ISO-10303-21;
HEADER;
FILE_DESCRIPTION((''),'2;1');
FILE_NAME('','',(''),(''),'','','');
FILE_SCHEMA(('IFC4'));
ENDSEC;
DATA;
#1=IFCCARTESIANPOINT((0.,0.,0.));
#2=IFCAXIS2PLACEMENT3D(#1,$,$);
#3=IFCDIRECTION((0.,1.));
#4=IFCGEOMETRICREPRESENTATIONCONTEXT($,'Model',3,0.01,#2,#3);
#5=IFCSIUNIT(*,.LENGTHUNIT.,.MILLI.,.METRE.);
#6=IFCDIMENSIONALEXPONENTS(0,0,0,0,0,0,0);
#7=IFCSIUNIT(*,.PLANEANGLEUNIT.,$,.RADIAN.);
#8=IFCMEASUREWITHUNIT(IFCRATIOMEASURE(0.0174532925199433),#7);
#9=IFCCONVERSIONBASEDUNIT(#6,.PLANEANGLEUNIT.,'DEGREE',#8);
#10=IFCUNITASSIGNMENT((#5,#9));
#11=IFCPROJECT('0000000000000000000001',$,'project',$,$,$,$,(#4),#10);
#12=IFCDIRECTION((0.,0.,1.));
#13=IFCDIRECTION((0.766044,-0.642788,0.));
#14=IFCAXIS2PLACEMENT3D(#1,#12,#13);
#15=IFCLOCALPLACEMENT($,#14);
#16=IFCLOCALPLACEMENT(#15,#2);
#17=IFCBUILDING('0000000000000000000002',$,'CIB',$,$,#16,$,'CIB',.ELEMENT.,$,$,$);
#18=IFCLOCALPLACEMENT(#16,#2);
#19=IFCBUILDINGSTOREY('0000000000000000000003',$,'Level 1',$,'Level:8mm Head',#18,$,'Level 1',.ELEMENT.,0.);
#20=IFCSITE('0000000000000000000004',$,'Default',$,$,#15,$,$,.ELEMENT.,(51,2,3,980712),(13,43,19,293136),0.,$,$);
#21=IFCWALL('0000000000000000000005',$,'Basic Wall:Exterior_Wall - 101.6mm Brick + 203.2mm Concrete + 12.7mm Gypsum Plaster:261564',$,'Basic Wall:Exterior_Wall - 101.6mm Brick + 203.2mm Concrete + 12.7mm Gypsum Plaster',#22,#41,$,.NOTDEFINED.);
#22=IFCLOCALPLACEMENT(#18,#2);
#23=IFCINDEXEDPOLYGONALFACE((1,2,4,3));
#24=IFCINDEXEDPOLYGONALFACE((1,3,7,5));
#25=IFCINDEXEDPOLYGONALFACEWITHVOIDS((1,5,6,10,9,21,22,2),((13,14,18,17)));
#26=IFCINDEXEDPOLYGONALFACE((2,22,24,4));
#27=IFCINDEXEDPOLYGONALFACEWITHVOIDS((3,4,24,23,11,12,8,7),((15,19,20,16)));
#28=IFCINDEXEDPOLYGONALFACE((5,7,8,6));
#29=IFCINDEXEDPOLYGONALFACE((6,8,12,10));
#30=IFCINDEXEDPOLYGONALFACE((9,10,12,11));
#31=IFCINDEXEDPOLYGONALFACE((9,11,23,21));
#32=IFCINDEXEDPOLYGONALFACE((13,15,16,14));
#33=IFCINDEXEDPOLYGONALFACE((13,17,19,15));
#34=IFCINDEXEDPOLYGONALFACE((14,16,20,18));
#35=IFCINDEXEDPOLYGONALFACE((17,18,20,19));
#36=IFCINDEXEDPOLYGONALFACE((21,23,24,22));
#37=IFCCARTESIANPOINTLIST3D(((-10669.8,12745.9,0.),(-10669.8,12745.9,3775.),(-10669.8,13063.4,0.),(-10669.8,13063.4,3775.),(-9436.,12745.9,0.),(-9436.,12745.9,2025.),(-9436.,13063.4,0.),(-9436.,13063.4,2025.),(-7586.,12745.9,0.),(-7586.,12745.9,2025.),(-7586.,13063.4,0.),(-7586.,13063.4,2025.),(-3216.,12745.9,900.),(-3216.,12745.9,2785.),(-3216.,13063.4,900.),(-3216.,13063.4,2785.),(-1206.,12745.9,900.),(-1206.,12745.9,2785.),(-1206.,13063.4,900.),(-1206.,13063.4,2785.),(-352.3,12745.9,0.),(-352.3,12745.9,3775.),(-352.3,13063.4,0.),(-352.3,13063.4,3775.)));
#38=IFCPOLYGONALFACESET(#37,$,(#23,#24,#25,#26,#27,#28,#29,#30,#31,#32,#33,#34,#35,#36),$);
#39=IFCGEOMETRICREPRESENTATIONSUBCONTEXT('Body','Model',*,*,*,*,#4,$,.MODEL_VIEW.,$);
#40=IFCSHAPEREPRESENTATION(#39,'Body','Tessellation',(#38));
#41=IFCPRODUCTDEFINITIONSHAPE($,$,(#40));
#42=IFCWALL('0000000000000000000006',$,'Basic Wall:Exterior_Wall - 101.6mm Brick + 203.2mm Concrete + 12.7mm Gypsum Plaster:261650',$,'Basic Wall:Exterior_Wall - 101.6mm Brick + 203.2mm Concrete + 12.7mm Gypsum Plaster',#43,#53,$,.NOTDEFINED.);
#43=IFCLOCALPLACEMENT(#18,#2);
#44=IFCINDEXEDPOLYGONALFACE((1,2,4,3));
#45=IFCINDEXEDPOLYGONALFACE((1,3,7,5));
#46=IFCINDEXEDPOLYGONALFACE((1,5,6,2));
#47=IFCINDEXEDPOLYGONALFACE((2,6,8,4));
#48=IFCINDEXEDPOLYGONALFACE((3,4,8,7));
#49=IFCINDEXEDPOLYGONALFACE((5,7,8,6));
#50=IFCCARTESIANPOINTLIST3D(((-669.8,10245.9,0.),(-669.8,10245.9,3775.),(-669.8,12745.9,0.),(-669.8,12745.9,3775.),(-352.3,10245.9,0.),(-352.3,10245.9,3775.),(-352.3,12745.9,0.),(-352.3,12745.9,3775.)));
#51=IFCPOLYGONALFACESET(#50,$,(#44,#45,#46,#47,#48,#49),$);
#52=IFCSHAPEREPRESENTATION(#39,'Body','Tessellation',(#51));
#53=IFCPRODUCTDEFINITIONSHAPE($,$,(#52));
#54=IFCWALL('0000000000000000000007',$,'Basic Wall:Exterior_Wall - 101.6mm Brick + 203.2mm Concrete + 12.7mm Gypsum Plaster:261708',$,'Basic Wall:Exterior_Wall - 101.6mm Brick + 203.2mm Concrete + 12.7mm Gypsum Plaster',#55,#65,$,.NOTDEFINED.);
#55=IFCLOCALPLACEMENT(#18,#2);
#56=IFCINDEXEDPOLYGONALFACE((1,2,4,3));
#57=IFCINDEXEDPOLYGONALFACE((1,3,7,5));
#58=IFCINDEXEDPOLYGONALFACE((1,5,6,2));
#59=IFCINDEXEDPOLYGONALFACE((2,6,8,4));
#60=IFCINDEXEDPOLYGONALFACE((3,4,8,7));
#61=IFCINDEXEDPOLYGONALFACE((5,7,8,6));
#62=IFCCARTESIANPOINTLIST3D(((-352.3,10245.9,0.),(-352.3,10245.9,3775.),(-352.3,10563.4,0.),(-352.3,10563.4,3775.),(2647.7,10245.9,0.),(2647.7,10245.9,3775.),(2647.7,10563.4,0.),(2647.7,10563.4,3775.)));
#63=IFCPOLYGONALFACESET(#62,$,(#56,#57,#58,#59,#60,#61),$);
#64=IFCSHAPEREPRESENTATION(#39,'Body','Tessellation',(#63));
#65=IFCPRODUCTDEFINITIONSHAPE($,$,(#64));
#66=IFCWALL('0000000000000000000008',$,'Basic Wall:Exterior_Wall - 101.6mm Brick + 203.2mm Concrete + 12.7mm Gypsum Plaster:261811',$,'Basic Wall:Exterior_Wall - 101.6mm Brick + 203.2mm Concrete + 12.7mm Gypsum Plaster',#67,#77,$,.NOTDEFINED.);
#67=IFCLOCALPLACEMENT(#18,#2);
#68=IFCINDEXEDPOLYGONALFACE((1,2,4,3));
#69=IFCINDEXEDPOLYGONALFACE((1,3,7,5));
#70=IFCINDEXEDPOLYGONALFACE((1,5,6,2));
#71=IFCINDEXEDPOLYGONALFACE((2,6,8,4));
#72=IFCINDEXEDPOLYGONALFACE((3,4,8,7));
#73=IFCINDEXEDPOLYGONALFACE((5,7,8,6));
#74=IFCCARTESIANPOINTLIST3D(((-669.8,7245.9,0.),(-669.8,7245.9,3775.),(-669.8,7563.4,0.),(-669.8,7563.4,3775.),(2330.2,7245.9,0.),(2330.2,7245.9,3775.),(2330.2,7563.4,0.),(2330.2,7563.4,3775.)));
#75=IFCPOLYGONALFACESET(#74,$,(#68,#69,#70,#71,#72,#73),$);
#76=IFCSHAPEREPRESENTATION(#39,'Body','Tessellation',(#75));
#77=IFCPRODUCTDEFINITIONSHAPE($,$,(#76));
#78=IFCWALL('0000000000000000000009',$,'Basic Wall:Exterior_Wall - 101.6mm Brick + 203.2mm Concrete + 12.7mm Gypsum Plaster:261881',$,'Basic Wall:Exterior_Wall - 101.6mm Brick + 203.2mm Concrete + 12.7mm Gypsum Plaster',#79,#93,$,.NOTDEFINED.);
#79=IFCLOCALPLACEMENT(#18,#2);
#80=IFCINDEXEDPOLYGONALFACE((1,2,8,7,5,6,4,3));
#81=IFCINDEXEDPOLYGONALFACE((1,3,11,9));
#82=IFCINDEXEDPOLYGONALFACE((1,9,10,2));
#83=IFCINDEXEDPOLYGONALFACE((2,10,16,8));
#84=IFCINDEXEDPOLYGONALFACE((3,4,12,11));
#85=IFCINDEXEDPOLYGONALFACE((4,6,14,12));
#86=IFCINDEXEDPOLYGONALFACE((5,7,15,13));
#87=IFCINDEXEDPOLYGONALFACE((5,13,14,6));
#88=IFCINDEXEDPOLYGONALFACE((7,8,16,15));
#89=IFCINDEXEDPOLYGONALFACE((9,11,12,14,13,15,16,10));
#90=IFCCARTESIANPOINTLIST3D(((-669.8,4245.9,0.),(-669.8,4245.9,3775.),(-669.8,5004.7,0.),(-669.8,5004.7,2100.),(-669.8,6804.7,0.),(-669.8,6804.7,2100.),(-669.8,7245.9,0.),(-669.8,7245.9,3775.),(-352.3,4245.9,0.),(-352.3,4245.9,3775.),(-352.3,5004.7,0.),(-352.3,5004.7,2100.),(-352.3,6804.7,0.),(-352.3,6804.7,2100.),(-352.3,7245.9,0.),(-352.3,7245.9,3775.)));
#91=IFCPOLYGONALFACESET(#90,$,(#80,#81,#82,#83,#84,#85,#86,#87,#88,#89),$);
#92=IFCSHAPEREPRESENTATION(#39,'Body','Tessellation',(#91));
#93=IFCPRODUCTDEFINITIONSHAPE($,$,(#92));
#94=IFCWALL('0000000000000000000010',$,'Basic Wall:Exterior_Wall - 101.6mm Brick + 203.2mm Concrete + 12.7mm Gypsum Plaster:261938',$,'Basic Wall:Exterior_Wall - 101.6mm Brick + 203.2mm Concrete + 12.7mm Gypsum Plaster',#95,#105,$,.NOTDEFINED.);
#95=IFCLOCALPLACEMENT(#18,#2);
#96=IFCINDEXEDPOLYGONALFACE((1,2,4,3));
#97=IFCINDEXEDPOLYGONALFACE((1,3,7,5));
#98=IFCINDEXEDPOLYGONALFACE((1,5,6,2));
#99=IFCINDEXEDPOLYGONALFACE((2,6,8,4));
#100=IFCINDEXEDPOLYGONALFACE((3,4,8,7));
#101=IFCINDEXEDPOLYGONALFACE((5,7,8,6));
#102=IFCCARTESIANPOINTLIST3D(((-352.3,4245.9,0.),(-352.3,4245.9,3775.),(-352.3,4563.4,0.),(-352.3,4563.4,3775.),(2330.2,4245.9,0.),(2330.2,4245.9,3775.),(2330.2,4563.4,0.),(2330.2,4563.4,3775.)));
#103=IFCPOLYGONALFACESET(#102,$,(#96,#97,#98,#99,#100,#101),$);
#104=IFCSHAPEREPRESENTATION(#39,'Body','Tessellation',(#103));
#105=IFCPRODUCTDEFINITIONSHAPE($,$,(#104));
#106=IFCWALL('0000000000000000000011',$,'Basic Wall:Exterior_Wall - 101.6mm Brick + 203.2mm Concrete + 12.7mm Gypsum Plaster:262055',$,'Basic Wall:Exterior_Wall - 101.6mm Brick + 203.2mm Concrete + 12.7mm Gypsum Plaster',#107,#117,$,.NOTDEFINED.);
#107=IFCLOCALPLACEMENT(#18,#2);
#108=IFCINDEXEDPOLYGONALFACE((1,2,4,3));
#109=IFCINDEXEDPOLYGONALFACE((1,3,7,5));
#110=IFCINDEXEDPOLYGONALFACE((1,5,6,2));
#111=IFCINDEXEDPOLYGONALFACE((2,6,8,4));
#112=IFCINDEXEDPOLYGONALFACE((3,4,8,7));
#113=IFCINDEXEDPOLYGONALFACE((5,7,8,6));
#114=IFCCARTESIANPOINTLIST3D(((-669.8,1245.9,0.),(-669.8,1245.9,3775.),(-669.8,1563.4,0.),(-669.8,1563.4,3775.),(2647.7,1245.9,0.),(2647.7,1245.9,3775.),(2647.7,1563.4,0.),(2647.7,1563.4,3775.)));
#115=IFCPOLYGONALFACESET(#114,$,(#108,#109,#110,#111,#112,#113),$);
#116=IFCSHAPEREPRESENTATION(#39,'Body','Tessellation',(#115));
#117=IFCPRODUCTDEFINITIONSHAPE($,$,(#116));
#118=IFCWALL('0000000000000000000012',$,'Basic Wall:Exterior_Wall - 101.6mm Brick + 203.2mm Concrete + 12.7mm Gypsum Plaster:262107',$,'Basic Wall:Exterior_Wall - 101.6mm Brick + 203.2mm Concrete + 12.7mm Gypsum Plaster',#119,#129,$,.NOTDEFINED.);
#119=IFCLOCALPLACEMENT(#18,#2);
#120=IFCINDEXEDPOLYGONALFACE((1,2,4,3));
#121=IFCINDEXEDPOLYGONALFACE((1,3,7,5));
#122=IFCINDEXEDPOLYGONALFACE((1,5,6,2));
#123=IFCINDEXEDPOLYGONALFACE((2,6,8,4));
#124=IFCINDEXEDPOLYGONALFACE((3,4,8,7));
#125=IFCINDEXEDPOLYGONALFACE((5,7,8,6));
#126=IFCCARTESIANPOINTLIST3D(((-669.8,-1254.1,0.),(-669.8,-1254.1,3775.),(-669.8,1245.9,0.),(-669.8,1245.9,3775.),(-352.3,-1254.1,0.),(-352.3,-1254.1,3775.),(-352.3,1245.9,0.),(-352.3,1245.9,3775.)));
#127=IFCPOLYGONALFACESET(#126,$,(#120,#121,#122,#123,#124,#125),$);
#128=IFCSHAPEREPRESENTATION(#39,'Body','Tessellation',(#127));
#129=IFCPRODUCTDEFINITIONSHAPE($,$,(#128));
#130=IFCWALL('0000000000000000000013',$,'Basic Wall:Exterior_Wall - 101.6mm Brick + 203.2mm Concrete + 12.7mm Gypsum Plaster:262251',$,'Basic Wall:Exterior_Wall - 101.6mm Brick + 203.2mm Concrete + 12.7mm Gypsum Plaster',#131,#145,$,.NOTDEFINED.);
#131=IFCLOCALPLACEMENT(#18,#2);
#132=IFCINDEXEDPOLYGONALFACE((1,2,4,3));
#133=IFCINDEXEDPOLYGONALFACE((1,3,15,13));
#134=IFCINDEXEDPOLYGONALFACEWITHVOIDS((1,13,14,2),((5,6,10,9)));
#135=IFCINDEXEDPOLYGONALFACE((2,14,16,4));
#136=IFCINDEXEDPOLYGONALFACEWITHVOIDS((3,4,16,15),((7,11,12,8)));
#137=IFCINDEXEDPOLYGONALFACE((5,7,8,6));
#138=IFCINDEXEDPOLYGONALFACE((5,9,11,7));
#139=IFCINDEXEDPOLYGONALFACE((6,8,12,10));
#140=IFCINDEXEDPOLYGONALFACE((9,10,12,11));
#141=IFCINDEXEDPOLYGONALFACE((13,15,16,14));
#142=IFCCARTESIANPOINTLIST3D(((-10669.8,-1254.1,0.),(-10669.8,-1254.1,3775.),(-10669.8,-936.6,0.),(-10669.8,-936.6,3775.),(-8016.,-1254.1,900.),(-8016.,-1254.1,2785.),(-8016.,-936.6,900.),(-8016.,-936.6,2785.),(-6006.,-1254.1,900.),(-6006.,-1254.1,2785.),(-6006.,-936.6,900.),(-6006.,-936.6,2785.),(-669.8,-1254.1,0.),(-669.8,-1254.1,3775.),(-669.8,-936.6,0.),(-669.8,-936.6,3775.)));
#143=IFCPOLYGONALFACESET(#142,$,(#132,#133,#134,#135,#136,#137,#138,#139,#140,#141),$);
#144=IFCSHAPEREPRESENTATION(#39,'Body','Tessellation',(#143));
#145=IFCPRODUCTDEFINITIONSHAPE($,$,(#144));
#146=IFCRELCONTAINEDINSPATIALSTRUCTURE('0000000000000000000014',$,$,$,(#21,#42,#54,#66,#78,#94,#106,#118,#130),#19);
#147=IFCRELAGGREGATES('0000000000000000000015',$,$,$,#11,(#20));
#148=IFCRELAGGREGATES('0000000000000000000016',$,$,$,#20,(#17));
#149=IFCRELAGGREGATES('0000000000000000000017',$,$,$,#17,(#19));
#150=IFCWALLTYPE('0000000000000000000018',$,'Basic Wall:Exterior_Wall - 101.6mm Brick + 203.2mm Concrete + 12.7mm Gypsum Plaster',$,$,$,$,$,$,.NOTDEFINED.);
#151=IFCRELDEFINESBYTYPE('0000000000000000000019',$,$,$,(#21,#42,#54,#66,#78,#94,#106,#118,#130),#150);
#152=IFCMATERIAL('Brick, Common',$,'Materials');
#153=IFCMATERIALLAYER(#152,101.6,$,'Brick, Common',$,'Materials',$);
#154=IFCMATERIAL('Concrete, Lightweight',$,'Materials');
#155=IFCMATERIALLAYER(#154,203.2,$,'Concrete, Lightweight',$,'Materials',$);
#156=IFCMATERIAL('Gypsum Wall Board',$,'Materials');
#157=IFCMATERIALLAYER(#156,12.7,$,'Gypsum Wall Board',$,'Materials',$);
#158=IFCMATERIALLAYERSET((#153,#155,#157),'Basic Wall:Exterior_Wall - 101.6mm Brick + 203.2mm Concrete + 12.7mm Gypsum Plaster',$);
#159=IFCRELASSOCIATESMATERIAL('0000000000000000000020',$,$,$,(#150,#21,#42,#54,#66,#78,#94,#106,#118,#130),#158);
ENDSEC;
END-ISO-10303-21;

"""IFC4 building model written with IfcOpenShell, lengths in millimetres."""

from ifc_helpers import new_model, entity, si_unit, converted_unit, direction, frame, frame_2d, origin, place, context, subcontext, project, spatial, polyline, rectangle, extrude, clip, bounded_halfspace, material, layer, layer_set, layer_usage, type_object, element, save


model = new_model("IFC4")

# Units and contexts
model_context = context("Model", 3, precision=0.01, world=origin(), true_north=direction((0.0, 1.0)))
body_context = subcontext(model_context, "Body", "Model", "MODEL_VIEW")
ifc_project = project(units=[si_unit("LENGTHUNIT", "METRE", prefix="MILLI"), converted_unit("PLANEANGLEUNIT", "DEGREE", entity("IfcRatioMeasure", 0.0174532925199433), si_unit("PLANEANGLEUNIT", "RADIAN"), dimensions=[0, 0, 0, 0, 0, 0, 0])], contexts=[model_context])

# Site, building, storey
site_placement = place(None, frame((0.0, 0.0, 0.0), z_axis=(0.0, 0.0, 1.0), x_axis=(0.766044, -0.642788, 0.0)))
site = spatial("IfcSite", under=ifc_project, at=site_placement, Name="Default", CompositionType="ELEMENT", RefLatitude=(51, 2, 3, 980712), RefLongitude=(13, 43, 19, 293136), RefElevation=0.0)
building_placement = place(site_placement, origin())
building = spatial("IfcBuilding", under=site, at=building_placement, Name="CIB", LongName="CIB", CompositionType="ELEMENT")
storey_placement = place(building_placement, origin())
storey = spatial("IfcBuildingStorey", under=building, at=storey_placement, Name="Level 1", ObjectType="Level:8mm Head", LongName="Level 1", CompositionType="ELEMENT", Elevation=0.0)

# Wall, openings
ifc_material_1 = material(Name="Brick, Common", Category="Materials")
ifc_layer_1 = layer(ifc_material_1, 101.6, Name="Brick, Common", Category="Materials")
ifc_material_2 = material(Name="Concrete, Lightweight", Category="Materials")
ifc_layer_2 = layer(ifc_material_2, 203.2, Name="Concrete, Lightweight", Category="Materials")
ifc_material_3 = material(Name="Gypsum Wall Board", Category="Materials")
ifc_layer_3 = layer(ifc_material_3, 12.7, Name="Gypsum Wall Board", Category="Materials")
ifc_layer_set_1 = layer_set([ifc_layer_1, ifc_layer_2, ifc_layer_3], Name="Basic Wall:Exterior_Wall - 101.6mm Brick + 203.2mm Concrete + 12.7mm Gypsum Plaster")
ifc_layer_usage_1 = layer_usage(ifc_layer_set_1, "AXIS2", "NEGATIVE", 158.8)
wall_type_1 = type_object("IfcWallType", Name="Basic Wall:Exterior_Wall - 101.6mm Brick + 203.2mm Concrete + 12.7mm Gypsum Plaster", PredefinedType="NOTDEFINED", material=ifc_layer_set_1)
wall_1_placement = place(storey_placement, frame((-10669.8, 12904.7, 0.0)))
wall_1 = element("IfcWall", 1, at=wall_1_placement, inside=storey, type_object=wall_type_1, material=ifc_layer_usage_1, Name="Basic Wall:Exterior_Wall - 101.6mm Brick + 203.2mm Concrete + 12.7mm Gypsum Plaster:261564", ObjectType="Basic Wall:Exterior_Wall - 101.6mm Brick + 203.2mm Concrete + 12.7mm Gypsum Plaster", PredefinedType="NOTDEFINED", context=body_context, shape_type="Clipping", body=[
    clip(extrude(rectangle(XDim=10317.5, YDim=317.5, at=frame_2d((5158.7, 0.0), x_axis=(-1.0, 0.0))), origin(), (0.0, 0.0, 1.0), 3775.0), bounded_halfspace(frame((0.0, -158.7, 3775.0), z_axis=(0.0, 0.0, -1.0), x_axis=(1.0, 0.0, 0.0)), True, frame((0.0, -158.7, 3775.0)), polyline([(0.0, 0.0), (317.5, 0.0), (10000.0, 0.0), (10317.5, 0.0), (10317.5, 317.5), (0.0, 317.5), (0.0, 0.0)]))),
])
opening_1_placement = place(wall_1_placement, frame((3083.8, 158.7, 0.0)))
element("IfcOpeningElement", 2, at=opening_1_placement, cuts=wall_1, ObjectType="Opening", PredefinedType="OPENING", context=body_context, shape_type="SweptSolid", body=[
    extrude(rectangle(XDim=2025.0, YDim=1850.0, at=frame_2d((1012.5, 925.0), x_axis=(1.0, 0.0))), frame((0.0, 0.0, 0.0), z_axis=(0.0, -1.0, 0.0), x_axis=(0.0, 0.0, 1.0)), (0.0, 0.0, 1.0), 317.5),
])
opening_2_placement = place(wall_1_placement, frame((9463.7, 158.7, 900.0)))
element("IfcOpeningElement", 3, at=opening_2_placement, cuts=wall_1, ObjectType="Opening", PredefinedType="OPENING", context=body_context, shape_type="SweptSolid", body=[
    extrude(rectangle(XDim=1885.0, YDim=2010.0, at=frame_2d((942.5, 1005.0), x_axis=(1.0, 0.0))), frame((0.0, 0.0, 0.0), z_axis=(0.0, -1.0, 0.0), x_axis=(0.0, 0.0, 1.0)), (0.0, 0.0, 1.0), 317.5),
])

# Walls
ifc_layer_usage_2 = layer_usage(ifc_layer_set_1, "AXIS2", "NEGATIVE", 158.8)
wall_2_placement = place(storey_placement, frame((-511.0, 12745.9, 0.0), z_axis=(0.0, 0.0, 1.0), x_axis=(0.0, -1.0, 0.0)))
element("IfcWall", 4, at=wall_2_placement, inside=storey, type_object=wall_type_1, material=ifc_layer_usage_2, Name="Basic Wall:Exterior_Wall - 101.6mm Brick + 203.2mm Concrete + 12.7mm Gypsum Plaster:261650", ObjectType="Basic Wall:Exterior_Wall - 101.6mm Brick + 203.2mm Concrete + 12.7mm Gypsum Plaster", PredefinedType="NOTDEFINED", context=body_context, shape_type="Clipping", body=[
    clip(extrude(rectangle(XDim=2500.0, YDim=317.5, at=frame_2d((1250.0, 0.0), x_axis=(-1.0, 0.0))), origin(), (0.0, 0.0, 1.0), 3775.0), bounded_halfspace(frame((0.0, -158.8, 3775.0), z_axis=(0.0, 0.0, -1.0), x_axis=(0.0, 1.0, 0.0)), True, frame((0.0, -158.8, 3775.0)), polyline([(0.0, 0.0), (2500.0, 0.0), (2500.0, 317.5), (2182.5, 317.5), (0.0, 317.5), (0.0, 0.0)]))),
])
ifc_layer_usage_3 = layer_usage(ifc_layer_set_1, "AXIS2", "NEGATIVE", 158.8)
wall_3_placement = place(storey_placement, frame((-352.3, 10404.7, 0.0)))
element("IfcWall", 5, at=wall_3_placement, inside=storey, type_object=wall_type_1, material=ifc_layer_usage_3, Name="Basic Wall:Exterior_Wall - 101.6mm Brick + 203.2mm Concrete + 12.7mm Gypsum Plaster:261708", ObjectType="Basic Wall:Exterior_Wall - 101.6mm Brick + 203.2mm Concrete + 12.7mm Gypsum Plaster", PredefinedType="NOTDEFINED", context=body_context, shape_type="Clipping", body=[
    clip(extrude(rectangle(XDim=3000.0, YDim=317.5, at=frame_2d((1500.0, 0.0), x_axis=(-1.0, 0.0))), origin(), (0.0, 0.0, 1.0), 3775.0), bounded_halfspace(frame((0.0, -158.7, 3775.0), z_axis=(0.0, 0.0, -1.0), x_axis=(1.0, 0.0, 0.0)), True, frame((0.0, -158.7, 3775.0)), polyline([(0.0, 0.0), (2682.5, 0.0), (3000.0, 0.0), (3000.0, 317.5), (0.0, 317.5), (0.0, 0.0)]))),
])
ifc_layer_usage_4 = layer_usage(ifc_layer_set_1, "AXIS2", "NEGATIVE", 158.8)
wall_4_placement = place(storey_placement, frame((2330.2, 7404.7, 0.0), z_axis=(0.0, 0.0, 1.0), x_axis=(-1.0, 0.0, 0.0)))
element("IfcWall", 6, at=wall_4_placement, inside=storey, type_object=wall_type_1, material=ifc_layer_usage_4, Name="Basic Wall:Exterior_Wall - 101.6mm Brick + 203.2mm Concrete + 12.7mm Gypsum Plaster:261811", ObjectType="Basic Wall:Exterior_Wall - 101.6mm Brick + 203.2mm Concrete + 12.7mm Gypsum Plaster", PredefinedType="NOTDEFINED", context=body_context, shape_type="Clipping", body=[
    clip(extrude(rectangle(XDim=3000.0, YDim=317.5, at=frame_2d((1500.0, 0.0), x_axis=(-1.0, 0.0))), origin(), (0.0, 0.0, 1.0), 3775.0), bounded_halfspace(frame((0.0, -158.8, 3775.0), z_axis=(0.0, 0.0, -1.0), x_axis=(-1.0, 0.0, 0.0)), True, frame((0.0, -158.8, 3775.0)), polyline([(0.0, 0.0), (3000.0, 0.0), (3000.0, 317.5), (2682.5, 317.5), (0.0, 317.5), (0.0, 0.0)]))),
])

# Wall, opening
ifc_layer_usage_5 = layer_usage(ifc_layer_set_1, "AXIS2", "NEGATIVE", 158.8)
wall_5_placement = place(storey_placement, frame((-511.0, 7245.9, 0.0), z_axis=(0.0, 0.0, 1.0), x_axis=(0.0, -1.0, 0.0)))
wall_5 = element("IfcWall", 7, at=wall_5_placement, inside=storey, type_object=wall_type_1, material=ifc_layer_usage_5, Name="Basic Wall:Exterior_Wall - 101.6mm Brick + 203.2mm Concrete + 12.7mm Gypsum Plaster:261881", ObjectType="Basic Wall:Exterior_Wall - 101.6mm Brick + 203.2mm Concrete + 12.7mm Gypsum Plaster", PredefinedType="NOTDEFINED", context=body_context, shape_type="Clipping", body=[
    clip(extrude(rectangle(XDim=3000.0, YDim=317.5, at=frame_2d((1500.0, 0.0), x_axis=(-1.0, 0.0))), origin(), (0.0, 0.0, 1.0), 3775.0), bounded_halfspace(frame((0.0, 158.8, 3775.0), z_axis=(0.0, 0.0, -1.0), x_axis=(0.0, 1.0, 0.0)), True, frame((0.0, 158.8, 3775.0)), polyline([(0.0, 0.0), (0.0, -317.5), (3000.0, -317.5), (3000.0, 0.0), (2682.5, 0.0), (0.0, 0.0)]))),
])
opening_3_placement = place(wall_5_placement, frame((2241.3, 158.8, 0.0)))
element("IfcOpeningElement", 8, at=opening_3_placement, cuts=wall_5, ObjectType="Opening", PredefinedType="OPENING", context=body_context, shape_type="SweptSolid", body=[
    extrude(rectangle(XDim=2100.0, YDim=1800.0, at=frame_2d((1050.0, 900.0), x_axis=(1.0, 0.0))), frame((0.0, 0.0, 0.0), z_axis=(0.0, -1.0, 0.0), x_axis=(0.0, 0.0, 1.0)), (0.0, 0.0, 1.0), 317.5),
])

# Walls
ifc_layer_usage_6 = layer_usage(ifc_layer_set_1, "AXIS2", "NEGATIVE", 158.8)
wall_6_placement = place(storey_placement, frame((-352.3, 4404.7, 0.0)))
element("IfcWall", 9, at=wall_6_placement, inside=storey, type_object=wall_type_1, material=ifc_layer_usage_6, Name="Basic Wall:Exterior_Wall - 101.6mm Brick + 203.2mm Concrete + 12.7mm Gypsum Plaster:261938", ObjectType="Basic Wall:Exterior_Wall - 101.6mm Brick + 203.2mm Concrete + 12.7mm Gypsum Plaster", PredefinedType="NOTDEFINED", context=body_context, shape_type="Clipping", body=[
    clip(extrude(rectangle(XDim=2682.5, YDim=317.5, at=frame_2d((1341.2, 0.0), x_axis=(-1.0, 0.0))), origin(), (0.0, 0.0, 1.0), 3775.0), bounded_halfspace(frame((0.0, -158.8, 3775.0), z_axis=(0.0, 0.0, -1.0), x_axis=(1.0, 0.0, 0.0)), True, frame((0.0, -158.8, 3775.0)), polyline([(0.0, 0.0), (2682.5, 0.0), (2682.5, 317.5), (0.0, 317.5), (0.0, 0.0)]))),
])
ifc_layer_usage_7 = layer_usage(ifc_layer_set_1, "AXIS2", "NEGATIVE", 158.8)
wall_7_placement = place(storey_placement, frame((2647.7, 1404.7, 0.0), z_axis=(0.0, 0.0, 1.0), x_axis=(-1.0, 0.0, 0.0)))
element("IfcWall", 10, at=wall_7_placement, inside=storey, type_object=wall_type_1, material=ifc_layer_usage_7, Name="Basic Wall:Exterior_Wall - 101.6mm Brick + 203.2mm Concrete + 12.7mm Gypsum Plaster:262055", ObjectType="Basic Wall:Exterior_Wall - 101.6mm Brick + 203.2mm Concrete + 12.7mm Gypsum Plaster", PredefinedType="NOTDEFINED", context=body_context, shape_type="Clipping", body=[
    clip(extrude(rectangle(XDim=3317.5, YDim=317.5, at=frame_2d((1658.7, 0.0), x_axis=(-1.0, 0.0))), origin(), (0.0, 0.0, 1.0), 3775.0), bounded_halfspace(frame((0.0, -158.8, 3775.0), z_axis=(0.0, 0.0, -1.0), x_axis=(-1.0, 0.0, 0.0)), True, frame((0.0, -158.8, 3775.0)), polyline([(0.0, 0.0), (317.5, 0.0), (3317.5, 0.0), (3317.5, 317.5), (3000.0, 317.5), (0.0, 317.5), (0.0, 0.0)]))),
])
ifc_layer_usage_8 = layer_usage(ifc_layer_set_1, "AXIS2", "NEGATIVE", 158.8)
wall_8_placement = place(storey_placement, frame((-511.0, 1245.9, 0.0), z_axis=(0.0, 0.0, 1.0), x_axis=(0.0, -1.0, 0.0)))
element("IfcWall", 11, at=wall_8_placement, inside=storey, type_object=wall_type_1, material=ifc_layer_usage_8, Name="Basic Wall:Exterior_Wall - 101.6mm Brick + 203.2mm Concrete + 12.7mm Gypsum Plaster:262107", ObjectType="Basic Wall:Exterior_Wall - 101.6mm Brick + 203.2mm Concrete + 12.7mm Gypsum Plaster", PredefinedType="NOTDEFINED", context=body_context, shape_type="Clipping", body=[
    clip(extrude(rectangle(XDim=2500.0, YDim=317.5, at=frame_2d((1250.0, 0.0), x_axis=(-1.0, 0.0))), origin(), (0.0, 0.0, 1.0), 3775.0), bounded_halfspace(frame((0.0, -158.8, 3775.0), z_axis=(0.0, 0.0, -1.0), x_axis=(0.0, 1.0, 0.0)), True, frame((0.0, -158.8, 3775.0)), polyline([(0.0, 0.0), (2182.5, 0.0), (2500.0, 0.0), (2500.0, 317.5), (0.0, 317.5), (0.0, 0.0)]))),
])

# Wall, opening
ifc_layer_usage_9 = layer_usage(ifc_layer_set_1, "AXIS2", "NEGATIVE", 158.8)
wall_9_placement = place(storey_placement, frame((-669.8, -1095.3, 0.0), z_axis=(0.0, 0.0, 1.0), x_axis=(-1.0, 0.0, 0.0)))
wall_9 = element("IfcWall", 12, at=wall_9_placement, inside=storey, type_object=wall_type_1, material=ifc_layer_usage_9, Name="Basic Wall:Exterior_Wall - 101.6mm Brick + 203.2mm Concrete + 12.7mm Gypsum Plaster:262251", ObjectType="Basic Wall:Exterior_Wall - 101.6mm Brick + 203.2mm Concrete + 12.7mm Gypsum Plaster", PredefinedType="NOTDEFINED", context=body_context, shape_type="Clipping", body=[
    clip(extrude(rectangle(XDim=10000.0, YDim=317.5, at=frame_2d((5000.0, 0.0), x_axis=(-1.0, 0.0))), origin(), (0.0, 0.0, 1.0), 3775.0), bounded_halfspace(frame((0.0, -158.8, 3775.0), z_axis=(0.0, 0.0, -1.0), x_axis=(-1.0, 0.0, 0.0)), True, frame((0.0, -158.8, 3775.0)), polyline([(0.0, 0.0), (9682.5, 0.0), (10000.0, 0.0), (10000.0, 317.5), (0.0, 317.5), (0.0, 0.0)]))),
])
opening_4_placement = place(wall_9_placement, frame((7346.2, 158.7, 900.0)))
element("IfcOpeningElement", 13, at=opening_4_placement, cuts=wall_9, ObjectType="Opening", PredefinedType="OPENING", context=body_context, shape_type="SweptSolid", body=[
    extrude(rectangle(XDim=1885.0, YDim=2010.0, at=frame_2d((942.5, 1005.0), x_axis=(1.0, 0.0))), frame((0.0, 0.0, 0.0), z_axis=(0.0, -1.0, 0.0), x_axis=(0.0, 0.0, 1.0)), (0.0, 0.0, 1.0), 317.5),
])

save(model, "model.ifc")
